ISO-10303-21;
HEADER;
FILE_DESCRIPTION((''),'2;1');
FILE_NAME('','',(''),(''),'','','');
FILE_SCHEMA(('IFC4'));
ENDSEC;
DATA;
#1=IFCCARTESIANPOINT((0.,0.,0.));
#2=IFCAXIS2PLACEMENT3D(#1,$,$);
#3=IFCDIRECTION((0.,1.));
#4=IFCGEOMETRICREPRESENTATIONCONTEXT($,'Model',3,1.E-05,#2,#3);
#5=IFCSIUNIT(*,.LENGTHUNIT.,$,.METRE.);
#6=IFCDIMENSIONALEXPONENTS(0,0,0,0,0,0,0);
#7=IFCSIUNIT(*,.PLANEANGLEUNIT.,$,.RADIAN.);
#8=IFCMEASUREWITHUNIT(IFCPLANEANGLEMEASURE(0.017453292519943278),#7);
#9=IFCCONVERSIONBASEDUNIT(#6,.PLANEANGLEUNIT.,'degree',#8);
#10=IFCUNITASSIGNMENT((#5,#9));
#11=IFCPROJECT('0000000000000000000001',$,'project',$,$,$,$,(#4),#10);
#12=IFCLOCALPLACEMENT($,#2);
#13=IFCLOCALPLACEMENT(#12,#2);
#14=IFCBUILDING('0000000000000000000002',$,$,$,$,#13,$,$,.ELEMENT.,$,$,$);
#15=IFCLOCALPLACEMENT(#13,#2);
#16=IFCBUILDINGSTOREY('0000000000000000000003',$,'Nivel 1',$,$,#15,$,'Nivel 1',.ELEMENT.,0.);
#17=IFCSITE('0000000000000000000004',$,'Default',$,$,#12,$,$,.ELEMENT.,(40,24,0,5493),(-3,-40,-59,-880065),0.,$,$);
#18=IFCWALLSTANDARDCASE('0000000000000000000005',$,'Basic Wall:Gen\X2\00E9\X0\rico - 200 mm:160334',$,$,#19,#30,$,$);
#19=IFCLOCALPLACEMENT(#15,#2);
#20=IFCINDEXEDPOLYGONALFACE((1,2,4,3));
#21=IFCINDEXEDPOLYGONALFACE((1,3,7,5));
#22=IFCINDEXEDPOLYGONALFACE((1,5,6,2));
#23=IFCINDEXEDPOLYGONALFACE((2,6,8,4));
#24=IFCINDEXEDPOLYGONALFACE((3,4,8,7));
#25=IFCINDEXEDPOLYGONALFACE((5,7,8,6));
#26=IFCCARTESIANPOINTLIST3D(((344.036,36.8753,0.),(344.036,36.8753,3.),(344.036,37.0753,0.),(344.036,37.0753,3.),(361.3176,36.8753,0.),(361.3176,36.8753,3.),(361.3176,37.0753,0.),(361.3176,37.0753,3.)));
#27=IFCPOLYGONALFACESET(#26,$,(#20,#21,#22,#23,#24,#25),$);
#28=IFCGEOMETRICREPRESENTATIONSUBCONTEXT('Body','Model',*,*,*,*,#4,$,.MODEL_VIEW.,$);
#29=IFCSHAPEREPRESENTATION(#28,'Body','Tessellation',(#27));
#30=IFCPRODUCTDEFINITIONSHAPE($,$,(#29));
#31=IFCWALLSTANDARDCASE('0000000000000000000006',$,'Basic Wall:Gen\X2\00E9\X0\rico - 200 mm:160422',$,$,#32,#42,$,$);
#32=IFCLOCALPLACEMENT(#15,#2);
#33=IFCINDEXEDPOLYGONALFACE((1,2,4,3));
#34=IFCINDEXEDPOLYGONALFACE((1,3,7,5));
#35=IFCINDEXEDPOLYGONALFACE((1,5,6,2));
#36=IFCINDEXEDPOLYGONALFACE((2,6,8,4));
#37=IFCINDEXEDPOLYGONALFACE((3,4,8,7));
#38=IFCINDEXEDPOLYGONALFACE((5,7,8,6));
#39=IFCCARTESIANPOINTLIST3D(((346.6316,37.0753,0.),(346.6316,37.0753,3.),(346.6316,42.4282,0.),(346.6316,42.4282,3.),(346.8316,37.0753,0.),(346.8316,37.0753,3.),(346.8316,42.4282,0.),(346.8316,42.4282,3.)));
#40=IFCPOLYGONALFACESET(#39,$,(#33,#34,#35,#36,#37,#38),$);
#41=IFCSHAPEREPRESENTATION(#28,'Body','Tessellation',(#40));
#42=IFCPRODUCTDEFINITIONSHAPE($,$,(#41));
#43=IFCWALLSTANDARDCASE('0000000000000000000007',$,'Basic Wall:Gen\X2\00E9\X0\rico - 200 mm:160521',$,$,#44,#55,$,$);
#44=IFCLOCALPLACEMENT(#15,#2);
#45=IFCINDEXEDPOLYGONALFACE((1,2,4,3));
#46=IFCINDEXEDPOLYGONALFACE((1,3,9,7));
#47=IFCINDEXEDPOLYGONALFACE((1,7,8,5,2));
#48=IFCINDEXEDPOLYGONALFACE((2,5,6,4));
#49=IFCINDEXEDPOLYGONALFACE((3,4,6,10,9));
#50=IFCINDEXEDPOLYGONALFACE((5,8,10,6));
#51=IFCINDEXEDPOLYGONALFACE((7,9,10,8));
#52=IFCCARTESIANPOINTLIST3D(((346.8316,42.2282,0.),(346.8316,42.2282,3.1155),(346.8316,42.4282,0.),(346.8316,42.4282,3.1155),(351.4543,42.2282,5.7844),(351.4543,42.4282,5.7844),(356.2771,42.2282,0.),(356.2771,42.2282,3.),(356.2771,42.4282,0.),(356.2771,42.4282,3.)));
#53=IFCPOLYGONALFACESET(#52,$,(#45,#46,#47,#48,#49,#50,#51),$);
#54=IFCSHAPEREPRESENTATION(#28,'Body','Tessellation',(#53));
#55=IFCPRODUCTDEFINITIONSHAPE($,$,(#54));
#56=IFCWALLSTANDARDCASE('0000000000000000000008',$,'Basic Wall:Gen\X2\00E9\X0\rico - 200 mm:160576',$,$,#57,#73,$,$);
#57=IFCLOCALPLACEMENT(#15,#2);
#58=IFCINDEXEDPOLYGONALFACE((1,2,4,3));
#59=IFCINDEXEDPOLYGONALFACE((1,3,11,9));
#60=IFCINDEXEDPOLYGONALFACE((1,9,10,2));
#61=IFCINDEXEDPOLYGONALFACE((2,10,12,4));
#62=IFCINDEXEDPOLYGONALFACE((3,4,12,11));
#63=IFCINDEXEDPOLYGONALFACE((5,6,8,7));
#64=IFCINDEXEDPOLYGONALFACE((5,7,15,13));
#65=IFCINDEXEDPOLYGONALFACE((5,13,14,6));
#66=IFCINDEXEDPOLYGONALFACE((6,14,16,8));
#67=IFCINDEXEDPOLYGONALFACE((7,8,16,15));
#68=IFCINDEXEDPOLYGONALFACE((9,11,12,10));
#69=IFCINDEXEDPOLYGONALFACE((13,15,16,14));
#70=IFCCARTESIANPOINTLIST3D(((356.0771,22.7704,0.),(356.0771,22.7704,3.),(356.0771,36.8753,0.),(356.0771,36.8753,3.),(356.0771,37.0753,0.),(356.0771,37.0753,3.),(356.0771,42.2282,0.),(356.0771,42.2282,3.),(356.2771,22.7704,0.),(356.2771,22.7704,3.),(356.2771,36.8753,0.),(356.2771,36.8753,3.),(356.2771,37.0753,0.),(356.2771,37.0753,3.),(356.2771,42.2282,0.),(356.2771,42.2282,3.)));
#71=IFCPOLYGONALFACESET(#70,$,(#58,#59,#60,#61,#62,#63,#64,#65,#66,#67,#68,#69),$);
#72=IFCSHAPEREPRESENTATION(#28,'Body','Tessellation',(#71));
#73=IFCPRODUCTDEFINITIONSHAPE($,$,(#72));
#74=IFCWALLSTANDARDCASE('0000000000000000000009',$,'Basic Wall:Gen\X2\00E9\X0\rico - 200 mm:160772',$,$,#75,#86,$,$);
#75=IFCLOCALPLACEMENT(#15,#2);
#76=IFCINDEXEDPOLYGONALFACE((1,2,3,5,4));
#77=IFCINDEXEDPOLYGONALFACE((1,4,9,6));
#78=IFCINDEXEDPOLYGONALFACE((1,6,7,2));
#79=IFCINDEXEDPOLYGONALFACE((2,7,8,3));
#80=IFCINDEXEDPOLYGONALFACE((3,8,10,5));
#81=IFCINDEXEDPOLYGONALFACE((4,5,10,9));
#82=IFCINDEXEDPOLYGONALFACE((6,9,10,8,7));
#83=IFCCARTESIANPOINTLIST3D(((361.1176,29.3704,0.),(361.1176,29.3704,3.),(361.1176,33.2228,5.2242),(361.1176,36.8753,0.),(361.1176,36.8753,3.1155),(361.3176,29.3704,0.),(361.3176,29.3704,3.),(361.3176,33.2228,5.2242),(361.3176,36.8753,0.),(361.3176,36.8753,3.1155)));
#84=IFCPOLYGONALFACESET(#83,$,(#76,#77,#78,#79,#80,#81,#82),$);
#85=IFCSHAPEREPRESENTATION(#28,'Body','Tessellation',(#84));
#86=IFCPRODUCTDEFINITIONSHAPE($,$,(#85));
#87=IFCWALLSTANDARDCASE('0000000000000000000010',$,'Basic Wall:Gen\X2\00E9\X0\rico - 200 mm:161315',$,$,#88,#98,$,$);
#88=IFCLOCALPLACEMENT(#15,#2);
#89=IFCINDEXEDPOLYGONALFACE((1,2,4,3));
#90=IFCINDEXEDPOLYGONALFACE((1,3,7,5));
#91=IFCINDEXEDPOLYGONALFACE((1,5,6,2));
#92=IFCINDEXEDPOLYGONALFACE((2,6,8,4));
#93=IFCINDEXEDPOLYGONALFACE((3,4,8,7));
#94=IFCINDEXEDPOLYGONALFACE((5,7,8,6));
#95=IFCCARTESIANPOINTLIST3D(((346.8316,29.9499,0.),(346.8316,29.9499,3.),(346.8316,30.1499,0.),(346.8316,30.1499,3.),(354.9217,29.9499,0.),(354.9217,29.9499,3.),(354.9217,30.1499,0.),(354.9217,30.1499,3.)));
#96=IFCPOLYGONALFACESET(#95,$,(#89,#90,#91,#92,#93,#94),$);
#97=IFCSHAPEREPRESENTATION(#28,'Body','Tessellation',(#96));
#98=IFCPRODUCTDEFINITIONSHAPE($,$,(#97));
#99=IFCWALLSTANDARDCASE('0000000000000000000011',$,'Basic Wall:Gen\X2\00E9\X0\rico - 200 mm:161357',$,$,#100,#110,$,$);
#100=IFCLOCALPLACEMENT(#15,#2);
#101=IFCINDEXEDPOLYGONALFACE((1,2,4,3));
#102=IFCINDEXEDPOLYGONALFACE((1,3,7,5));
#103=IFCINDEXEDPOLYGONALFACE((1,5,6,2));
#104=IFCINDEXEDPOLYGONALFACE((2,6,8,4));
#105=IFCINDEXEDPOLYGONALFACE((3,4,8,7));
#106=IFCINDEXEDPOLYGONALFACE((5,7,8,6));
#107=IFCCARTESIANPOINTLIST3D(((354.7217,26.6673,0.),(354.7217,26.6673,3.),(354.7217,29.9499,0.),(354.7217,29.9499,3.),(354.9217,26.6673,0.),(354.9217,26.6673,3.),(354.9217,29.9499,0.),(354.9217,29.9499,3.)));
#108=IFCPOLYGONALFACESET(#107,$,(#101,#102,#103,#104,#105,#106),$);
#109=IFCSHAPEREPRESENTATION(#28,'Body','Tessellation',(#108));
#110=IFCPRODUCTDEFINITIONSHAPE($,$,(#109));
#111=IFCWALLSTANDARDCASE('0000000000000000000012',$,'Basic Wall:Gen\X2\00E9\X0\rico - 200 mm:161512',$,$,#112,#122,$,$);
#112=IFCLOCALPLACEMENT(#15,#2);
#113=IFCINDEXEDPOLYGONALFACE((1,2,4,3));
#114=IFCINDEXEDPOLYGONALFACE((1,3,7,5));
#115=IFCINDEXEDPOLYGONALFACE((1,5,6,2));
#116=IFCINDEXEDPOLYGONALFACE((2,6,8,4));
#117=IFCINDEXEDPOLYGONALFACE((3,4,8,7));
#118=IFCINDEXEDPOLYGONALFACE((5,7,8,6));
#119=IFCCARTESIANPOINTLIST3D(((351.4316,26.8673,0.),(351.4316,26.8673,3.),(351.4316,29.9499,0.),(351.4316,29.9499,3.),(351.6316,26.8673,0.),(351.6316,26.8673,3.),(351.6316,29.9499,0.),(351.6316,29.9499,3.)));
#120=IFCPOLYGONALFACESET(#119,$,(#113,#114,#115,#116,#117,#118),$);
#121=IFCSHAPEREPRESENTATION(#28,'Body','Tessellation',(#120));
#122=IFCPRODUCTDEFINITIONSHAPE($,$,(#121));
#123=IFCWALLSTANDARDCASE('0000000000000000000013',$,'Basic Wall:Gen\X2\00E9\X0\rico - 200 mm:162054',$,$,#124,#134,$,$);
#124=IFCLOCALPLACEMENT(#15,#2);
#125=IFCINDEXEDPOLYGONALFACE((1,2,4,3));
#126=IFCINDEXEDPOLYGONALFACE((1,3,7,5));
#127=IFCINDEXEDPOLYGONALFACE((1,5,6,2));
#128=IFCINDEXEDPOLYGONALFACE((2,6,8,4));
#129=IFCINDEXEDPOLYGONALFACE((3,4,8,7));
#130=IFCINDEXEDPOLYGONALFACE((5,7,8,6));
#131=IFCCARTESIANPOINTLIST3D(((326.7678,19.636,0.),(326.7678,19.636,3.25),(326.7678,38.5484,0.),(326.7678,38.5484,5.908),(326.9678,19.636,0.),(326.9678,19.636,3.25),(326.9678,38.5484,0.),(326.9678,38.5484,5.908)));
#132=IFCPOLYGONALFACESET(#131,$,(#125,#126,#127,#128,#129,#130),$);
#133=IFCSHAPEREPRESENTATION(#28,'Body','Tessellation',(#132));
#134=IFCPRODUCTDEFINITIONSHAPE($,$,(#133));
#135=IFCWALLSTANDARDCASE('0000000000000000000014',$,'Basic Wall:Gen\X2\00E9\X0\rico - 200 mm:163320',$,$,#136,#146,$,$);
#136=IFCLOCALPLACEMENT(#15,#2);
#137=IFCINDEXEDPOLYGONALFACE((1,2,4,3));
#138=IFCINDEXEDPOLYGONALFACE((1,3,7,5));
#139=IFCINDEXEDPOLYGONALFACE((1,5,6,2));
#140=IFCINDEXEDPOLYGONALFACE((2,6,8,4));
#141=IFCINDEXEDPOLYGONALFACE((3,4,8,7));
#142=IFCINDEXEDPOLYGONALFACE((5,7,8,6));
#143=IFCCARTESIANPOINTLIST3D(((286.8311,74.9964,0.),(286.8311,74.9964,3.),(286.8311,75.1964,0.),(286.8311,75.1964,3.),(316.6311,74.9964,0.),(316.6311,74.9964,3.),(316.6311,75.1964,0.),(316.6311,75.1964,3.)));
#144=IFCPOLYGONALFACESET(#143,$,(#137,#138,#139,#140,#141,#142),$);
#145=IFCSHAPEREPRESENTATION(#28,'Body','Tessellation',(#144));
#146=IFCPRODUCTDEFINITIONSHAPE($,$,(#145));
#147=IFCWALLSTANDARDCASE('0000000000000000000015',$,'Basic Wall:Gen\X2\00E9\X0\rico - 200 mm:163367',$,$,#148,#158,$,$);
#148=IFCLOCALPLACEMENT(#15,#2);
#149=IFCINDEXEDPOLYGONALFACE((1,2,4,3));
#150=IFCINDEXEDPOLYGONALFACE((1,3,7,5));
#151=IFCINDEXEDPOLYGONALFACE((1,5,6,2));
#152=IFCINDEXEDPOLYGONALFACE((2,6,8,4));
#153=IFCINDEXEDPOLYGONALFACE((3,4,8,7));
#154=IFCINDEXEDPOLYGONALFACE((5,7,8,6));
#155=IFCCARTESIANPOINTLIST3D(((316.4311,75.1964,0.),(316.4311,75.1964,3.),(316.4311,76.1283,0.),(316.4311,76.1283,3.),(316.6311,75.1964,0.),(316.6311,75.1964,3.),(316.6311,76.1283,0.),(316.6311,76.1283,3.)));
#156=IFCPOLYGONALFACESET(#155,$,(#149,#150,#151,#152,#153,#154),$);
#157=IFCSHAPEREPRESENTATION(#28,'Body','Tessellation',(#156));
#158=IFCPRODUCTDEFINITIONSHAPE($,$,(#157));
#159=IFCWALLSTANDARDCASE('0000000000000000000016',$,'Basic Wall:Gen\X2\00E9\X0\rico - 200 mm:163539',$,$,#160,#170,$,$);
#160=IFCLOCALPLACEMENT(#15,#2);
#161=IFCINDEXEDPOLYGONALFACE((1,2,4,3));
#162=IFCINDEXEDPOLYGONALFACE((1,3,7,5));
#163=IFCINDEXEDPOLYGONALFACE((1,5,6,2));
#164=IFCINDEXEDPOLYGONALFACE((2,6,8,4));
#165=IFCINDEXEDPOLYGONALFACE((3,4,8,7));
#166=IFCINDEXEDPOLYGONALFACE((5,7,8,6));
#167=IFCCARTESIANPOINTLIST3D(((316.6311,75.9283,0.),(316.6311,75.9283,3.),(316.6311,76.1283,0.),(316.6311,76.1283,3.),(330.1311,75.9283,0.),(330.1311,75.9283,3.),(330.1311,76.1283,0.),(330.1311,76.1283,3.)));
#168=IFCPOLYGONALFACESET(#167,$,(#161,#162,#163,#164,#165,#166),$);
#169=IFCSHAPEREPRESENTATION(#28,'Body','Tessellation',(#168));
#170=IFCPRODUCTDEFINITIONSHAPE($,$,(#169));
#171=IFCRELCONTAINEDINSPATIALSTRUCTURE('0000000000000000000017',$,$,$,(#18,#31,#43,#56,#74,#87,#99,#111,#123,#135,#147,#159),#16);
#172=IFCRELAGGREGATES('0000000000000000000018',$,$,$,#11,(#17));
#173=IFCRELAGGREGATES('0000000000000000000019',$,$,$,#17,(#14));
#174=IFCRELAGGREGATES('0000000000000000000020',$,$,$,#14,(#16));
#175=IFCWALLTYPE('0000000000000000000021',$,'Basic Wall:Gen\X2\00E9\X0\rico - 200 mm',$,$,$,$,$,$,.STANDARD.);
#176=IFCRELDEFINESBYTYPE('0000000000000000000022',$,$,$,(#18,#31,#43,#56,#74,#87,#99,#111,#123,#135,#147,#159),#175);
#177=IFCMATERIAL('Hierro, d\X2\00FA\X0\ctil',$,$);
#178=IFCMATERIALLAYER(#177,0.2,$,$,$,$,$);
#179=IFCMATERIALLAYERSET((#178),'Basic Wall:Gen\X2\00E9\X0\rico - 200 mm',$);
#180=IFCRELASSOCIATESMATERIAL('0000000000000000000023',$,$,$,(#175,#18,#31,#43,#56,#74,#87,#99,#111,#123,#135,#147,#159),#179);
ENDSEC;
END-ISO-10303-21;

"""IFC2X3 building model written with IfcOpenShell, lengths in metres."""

from ifc_helpers import new_model, entity, si_unit, converted_unit, direction, frame, frame_2d, origin, place, context, subcontext, project, spatial, polyline, rectangle, extrude, clip, bounded_halfspace, material, layer, layer_set, layer_usage, type_object, element, save


model = new_model("IFC2X3")

# Units and contexts
model_context = context("Model", 3, precision=1e-05, world=origin(), true_north=direction((0.0, 1.0)))
body_context = subcontext(model_context, "Body", "Model", "MODEL_VIEW")
ifc_project = project(units=[si_unit("LENGTHUNIT", "METRE"), converted_unit("PLANEANGLEUNIT", "degree", entity("IfcPlaneAngleMeasure", 0.017453292519943278), si_unit("PLANEANGLEUNIT", "RADIAN"), dimensions=[0, 0, 0, 0, 0, 0, 0])], contexts=[model_context])

# Site, building, storey
site_placement = place(None, origin())
site = spatial("IfcSite", under=ifc_project, at=site_placement, Name="Default", CompositionType="ELEMENT", RefLatitude=(40, 24, 0, 5493), RefLongitude=(-3, -40, -59, -880065), RefElevation=0.0)
building_placement = place(site_placement, origin())
building = spatial("IfcBuilding", under=site, at=building_placement, CompositionType="ELEMENT")
storey_placement = place(building_placement, origin())
storey = spatial("IfcBuildingStorey", under=building, at=storey_placement, Name="Nivel 1", LongName="Nivel 1", CompositionType="ELEMENT", Elevation=0.0)

# Walls
ifc_material = material(Name="Hierro, dúctil")
ifc_layer = layer(ifc_material, 0.2)
ifc_layer_set = layer_set([ifc_layer], Name="Basic Wall:Genérico - 200 mm")
ifc_layer_usage_1 = layer_usage(ifc_layer_set, "AXIS2", "NEGATIVE", 0.1)
wall_type = type_object("IfcWallType", Name="Basic Wall:Genérico - 200 mm", PredefinedType="STANDARD", material=ifc_layer_set)
wall_1_placement = place(storey_placement, frame((344.036, 36.9753, 0.0)))
element("IfcWallStandardCase", 1, at=wall_1_placement, inside=storey, type_object=wall_type, material=ifc_layer_usage_1, Name="Basic Wall:Genérico - 200 mm:160334", context=body_context, shape_type="SweptSolid", body=[
    extrude(rectangle(XDim=17.2816, YDim=0.2, at=frame_2d((8.6408, 0.0), x_axis=(-1.0, 0.0))), origin(), (0.0, 0.0, 1.0), 3.0),
])
ifc_layer_usage_2 = layer_usage(ifc_layer_set, "AXIS2", "NEGATIVE", 0.1)
wall_2_placement = place(storey_placement, frame((346.7316, 37.0753, 0.0), z_axis=(0.0, 0.0, 1.0), x_axis=(0.0, 1.0, 0.0)))
element("IfcWallStandardCase", 2, at=wall_2_placement, inside=storey, type_object=wall_type, material=ifc_layer_usage_2, Name="Basic Wall:Genérico - 200 mm:160422", context=body_context, shape_type="SweptSolid", body=[
    extrude(rectangle(XDim=5.3529, YDim=0.2, at=frame_2d((2.6765, 0.0), x_axis=(-1.0, 0.0))), origin(), (0.0, 0.0, 1.0), 3.0),
])
ifc_layer_usage_3 = layer_usage(ifc_layer_set, "AXIS2", "NEGATIVE", 0.1)
wall_3_placement = place(storey_placement, frame((346.8316, 42.3282, 0.0)))
element("IfcWallStandardCase", 3, at=wall_3_placement, inside=storey, type_object=wall_type, material=ifc_layer_usage_3, Name="Basic Wall:Genérico - 200 mm:160521", context=body_context, shape_type="Clipping", body=[
    clip(clip(extrude(rectangle(XDim=9.4456, YDim=0.2, at=frame_2d((4.7228, 0.0), x_axis=(-1.0, 0.0))), origin(), (0.0, 0.0, 1.0), 5.7844), bounded_halfspace(frame((4.6228, -0.1, 5.7844), z_axis=(0.5, 0.0, 0.866025), x_axis=(0.0, 1.0, 0.0)), False, frame((4.6228, -0.1, 5.7844)), polyline([(0.0, 0.0), (4.8228, 0.0), (4.8228, 0.2), (0.0, 0.2), (0.0, 0.0)]))), bounded_halfspace(frame((0.0, -0.1, 3.1155), z_axis=(-0.5, 0.0, 0.866025), x_axis=(0.0, -1.0, 0.0)), False, frame((0.0, -0.1, 3.1155)), polyline([(0.0, 0.0), (4.6228, 0.0), (4.6228, 0.2), (0.0, 0.2), (0.0, 0.0)]))),
])

# Wall, opening
ifc_layer_usage_4 = layer_usage(ifc_layer_set, "AXIS2", "NEGATIVE", 0.1)
wall_4_placement = place(storey_placement, frame((356.1771, 42.2282, 0.0), z_axis=(0.0, 0.0, 1.0), x_axis=(0.0, -1.0, 0.0)))
wall_4 = element("IfcWallStandardCase", 4, at=wall_4_placement, inside=storey, type_object=wall_type, material=ifc_layer_usage_4, Name="Basic Wall:Genérico - 200 mm:160576", context=body_context, shape_type="SweptSolid", body=[
    extrude(rectangle(XDim=19.4577, YDim=0.2, at=frame_2d((9.7289, 0.0), x_axis=(-1.0, 0.0))), origin(), (0.0, 0.0, 1.0), 3.0),
])
opening_placement = place(storey_placement, frame((356.1771, 42.2282, 0.0), z_axis=(0.0, 0.0, 1.0), x_axis=(0.0, -1.0, 0.0)))
element("IfcOpeningElement", 5, at=opening_placement, cuts=wall_4, ObjectType="Opening", context=body_context, shape_type="SweptSolid", body=[
    extrude(rectangle(XDim=3.0, YDim=0.2, at=frame_2d((0.0, 0.0), x_axis=(1.0, 0.0))), frame((5.3529, 0.0, 1.5), z_axis=(-1.0, 0.0, 0.0), x_axis=(0.0, 0.0, 1.0)), (0.0, 0.0, 1.0), 0.2),
])

# Walls
ifc_layer_usage_5 = layer_usage(ifc_layer_set, "AXIS2", "NEGATIVE", 0.1)
wall_5_placement = place(storey_placement, frame((361.2176, 36.8753, 0.0), z_axis=(0.0, 0.0, 1.0), x_axis=(0.0, -1.0, 0.0)))
element("IfcWallStandardCase", 6, at=wall_5_placement, inside=storey, type_object=wall_type, material=ifc_layer_usage_5, Name="Basic Wall:Genérico - 200 mm:160772", context=body_context, shape_type="Clipping", body=[
    clip(clip(extrude(rectangle(XDim=7.5048, YDim=0.2, at=frame_2d((3.7524, 0.0), x_axis=(-1.0, 0.0))), origin(), (0.0, 0.0, 1.0), 5.2242), bounded_halfspace(frame((0.0, -0.1, 3.1155), z_axis=(-0.5, 0.0, 0.866025), x_axis=(0.0, -1.0, 0.0)), False, frame((0.0, -0.1, 3.1155)), polyline([(0.0, 0.0), (3.6524, 0.0), (3.6524, 0.2), (0.0, 0.2), (0.0, 0.0)]))), bounded_halfspace(frame((3.6524, -0.1, 5.2242), z_axis=(0.5, 0.0, 0.866025), x_axis=(0.0, 1.0, 0.0)), False, frame((3.6524, -0.1, 5.2242)), polyline([(0.0, 0.0), (3.8524, 0.0), (3.8524, 0.2), (0.0, 0.2), (0.0, 0.0)]))),
])
ifc_layer_usage_6 = layer_usage(ifc_layer_set, "AXIS2", "NEGATIVE", 0.1)
wall_6_placement = place(storey_placement, frame((346.8316, 30.0499, 0.0)))
element("IfcWallStandardCase", 7, at=wall_6_placement, inside=storey, type_object=wall_type, material=ifc_layer_usage_6, Name="Basic Wall:Genérico - 200 mm:161315", context=body_context, shape_type="SweptSolid", body=[
    extrude(rectangle(XDim=8.0902, YDim=0.2, at=frame_2d((4.0451, 0.0), x_axis=(-1.0, 0.0))), origin(), (0.0, 0.0, 1.0), 3.0),
])
ifc_layer_usage_7 = layer_usage(ifc_layer_set, "AXIS2", "NEGATIVE", 0.1)
wall_7_placement = place(storey_placement, frame((354.8217, 29.9499, 0.0), z_axis=(0.0, 0.0, 1.0), x_axis=(0.0, -1.0, 0.0)))
element("IfcWallStandardCase", 8, at=wall_7_placement, inside=storey, type_object=wall_type, material=ifc_layer_usage_7, Name="Basic Wall:Genérico - 200 mm:161357", context=body_context, shape_type="SweptSolid", body=[
    extrude(rectangle(XDim=3.2827, YDim=0.2, at=frame_2d((1.6413, 0.0), x_axis=(-1.0, 0.0))), origin(), (0.0, 0.0, 1.0), 3.0),
])
ifc_layer_usage_8 = layer_usage(ifc_layer_set, "AXIS2", "NEGATIVE", 0.1)
wall_8_placement = place(storey_placement, frame((351.5316, 29.9499, 0.0), z_axis=(0.0, 0.0, 1.0), x_axis=(0.0, -1.0, 0.0)))
element("IfcWallStandardCase", 9, at=wall_8_placement, inside=storey, type_object=wall_type, material=ifc_layer_usage_8, Name="Basic Wall:Genérico - 200 mm:161512", context=body_context, shape_type="SweptSolid", body=[
    extrude(rectangle(XDim=3.0827, YDim=0.2, at=frame_2d((1.5413, 0.0), x_axis=(-1.0, 0.0))), origin(), (0.0, 0.0, 1.0), 3.0),
])
ifc_layer_usage_9 = layer_usage(ifc_layer_set, "AXIS2", "NEGATIVE", 0.1)
wall_9_placement = place(storey_placement, frame((326.8678, 38.5484, 0.0), z_axis=(0.0, 0.0, 1.0), x_axis=(0.0, -1.0, 0.0)))
element("IfcWallStandardCase", 10, at=wall_9_placement, inside=storey, type_object=wall_type, material=ifc_layer_usage_9, Name="Basic Wall:Genérico - 200 mm:162054", context=body_context, shape_type="Clipping", body=[
    clip(extrude(rectangle(XDim=18.9123, YDim=0.2, at=frame_2d((9.4562, 0.0), x_axis=(-1.0, 0.0))), origin(), (0.0, 0.0, 1.0), 5.908), bounded_halfspace(frame((0.0, -0.1, 5.908), z_axis=(0.139173, 0.0, 0.990268), x_axis=(0.0, 1.0, 0.0)), False, frame((0.0, -0.1, 5.908)), polyline([(0.0, 0.0), (18.7123, 0.0), (18.9123, 0.0), (18.9123, 0.2), (0.0, 0.2), (0.0, 0.0)]))),
])
ifc_layer_usage_10 = layer_usage(ifc_layer_set, "AXIS2", "NEGATIVE", 0.1)
wall_10_placement = place(storey_placement, frame((316.6311, 75.0964, 0.0), z_axis=(0.0, 0.0, 1.0), x_axis=(-1.0, 0.0, 0.0)))
element("IfcWallStandardCase", 11, at=wall_10_placement, inside=storey, type_object=wall_type, material=ifc_layer_usage_10, Name="Basic Wall:Genérico - 200 mm:163320", context=body_context, shape_type="SweptSolid", body=[
    extrude(rectangle(XDim=29.8, YDim=0.2, at=frame_2d((14.9, 0.0), x_axis=(-1.0, 0.0))), origin(), (0.0, 0.0, 1.0), 3.0),
])
ifc_layer_usage_11 = layer_usage(ifc_layer_set, "AXIS2", "NEGATIVE", 0.1)
wall_11_placement = place(storey_placement, frame((316.5311, 75.1964, 0.0), z_axis=(0.0, 0.0, 1.0), x_axis=(0.0, 1.0, 0.0)))
element("IfcWallStandardCase", 12, at=wall_11_placement, inside=storey, type_object=wall_type, material=ifc_layer_usage_11, Name="Basic Wall:Genérico - 200 mm:163367", context=body_context, shape_type="SweptSolid", body=[
    extrude(rectangle(XDim=0.9319, YDim=0.2, at=frame_2d((0.4659, 0.0), x_axis=(-1.0, 0.0))), origin(), (0.0, 0.0, 1.0), 3.0),
])
ifc_layer_usage_12 = layer_usage(ifc_layer_set, "AXIS2", "NEGATIVE", 0.1)
wall_12_placement = place(storey_placement, frame((316.6311, 76.0283, 0.0)))
element("IfcWallStandardCase", 13, at=wall_12_placement, inside=storey, type_object=wall_type, material=ifc_layer_usage_12, Name="Basic Wall:Genérico - 200 mm:163539", context=body_context, shape_type="SweptSolid", body=[
    extrude(rectangle(XDim=13.5, YDim=0.2, at=frame_2d((6.75, 0.0), x_axis=(-1.0, 0.0))), origin(), (0.0, 0.0, 1.0), 3.0),
])

save(model, "model.ifc")
